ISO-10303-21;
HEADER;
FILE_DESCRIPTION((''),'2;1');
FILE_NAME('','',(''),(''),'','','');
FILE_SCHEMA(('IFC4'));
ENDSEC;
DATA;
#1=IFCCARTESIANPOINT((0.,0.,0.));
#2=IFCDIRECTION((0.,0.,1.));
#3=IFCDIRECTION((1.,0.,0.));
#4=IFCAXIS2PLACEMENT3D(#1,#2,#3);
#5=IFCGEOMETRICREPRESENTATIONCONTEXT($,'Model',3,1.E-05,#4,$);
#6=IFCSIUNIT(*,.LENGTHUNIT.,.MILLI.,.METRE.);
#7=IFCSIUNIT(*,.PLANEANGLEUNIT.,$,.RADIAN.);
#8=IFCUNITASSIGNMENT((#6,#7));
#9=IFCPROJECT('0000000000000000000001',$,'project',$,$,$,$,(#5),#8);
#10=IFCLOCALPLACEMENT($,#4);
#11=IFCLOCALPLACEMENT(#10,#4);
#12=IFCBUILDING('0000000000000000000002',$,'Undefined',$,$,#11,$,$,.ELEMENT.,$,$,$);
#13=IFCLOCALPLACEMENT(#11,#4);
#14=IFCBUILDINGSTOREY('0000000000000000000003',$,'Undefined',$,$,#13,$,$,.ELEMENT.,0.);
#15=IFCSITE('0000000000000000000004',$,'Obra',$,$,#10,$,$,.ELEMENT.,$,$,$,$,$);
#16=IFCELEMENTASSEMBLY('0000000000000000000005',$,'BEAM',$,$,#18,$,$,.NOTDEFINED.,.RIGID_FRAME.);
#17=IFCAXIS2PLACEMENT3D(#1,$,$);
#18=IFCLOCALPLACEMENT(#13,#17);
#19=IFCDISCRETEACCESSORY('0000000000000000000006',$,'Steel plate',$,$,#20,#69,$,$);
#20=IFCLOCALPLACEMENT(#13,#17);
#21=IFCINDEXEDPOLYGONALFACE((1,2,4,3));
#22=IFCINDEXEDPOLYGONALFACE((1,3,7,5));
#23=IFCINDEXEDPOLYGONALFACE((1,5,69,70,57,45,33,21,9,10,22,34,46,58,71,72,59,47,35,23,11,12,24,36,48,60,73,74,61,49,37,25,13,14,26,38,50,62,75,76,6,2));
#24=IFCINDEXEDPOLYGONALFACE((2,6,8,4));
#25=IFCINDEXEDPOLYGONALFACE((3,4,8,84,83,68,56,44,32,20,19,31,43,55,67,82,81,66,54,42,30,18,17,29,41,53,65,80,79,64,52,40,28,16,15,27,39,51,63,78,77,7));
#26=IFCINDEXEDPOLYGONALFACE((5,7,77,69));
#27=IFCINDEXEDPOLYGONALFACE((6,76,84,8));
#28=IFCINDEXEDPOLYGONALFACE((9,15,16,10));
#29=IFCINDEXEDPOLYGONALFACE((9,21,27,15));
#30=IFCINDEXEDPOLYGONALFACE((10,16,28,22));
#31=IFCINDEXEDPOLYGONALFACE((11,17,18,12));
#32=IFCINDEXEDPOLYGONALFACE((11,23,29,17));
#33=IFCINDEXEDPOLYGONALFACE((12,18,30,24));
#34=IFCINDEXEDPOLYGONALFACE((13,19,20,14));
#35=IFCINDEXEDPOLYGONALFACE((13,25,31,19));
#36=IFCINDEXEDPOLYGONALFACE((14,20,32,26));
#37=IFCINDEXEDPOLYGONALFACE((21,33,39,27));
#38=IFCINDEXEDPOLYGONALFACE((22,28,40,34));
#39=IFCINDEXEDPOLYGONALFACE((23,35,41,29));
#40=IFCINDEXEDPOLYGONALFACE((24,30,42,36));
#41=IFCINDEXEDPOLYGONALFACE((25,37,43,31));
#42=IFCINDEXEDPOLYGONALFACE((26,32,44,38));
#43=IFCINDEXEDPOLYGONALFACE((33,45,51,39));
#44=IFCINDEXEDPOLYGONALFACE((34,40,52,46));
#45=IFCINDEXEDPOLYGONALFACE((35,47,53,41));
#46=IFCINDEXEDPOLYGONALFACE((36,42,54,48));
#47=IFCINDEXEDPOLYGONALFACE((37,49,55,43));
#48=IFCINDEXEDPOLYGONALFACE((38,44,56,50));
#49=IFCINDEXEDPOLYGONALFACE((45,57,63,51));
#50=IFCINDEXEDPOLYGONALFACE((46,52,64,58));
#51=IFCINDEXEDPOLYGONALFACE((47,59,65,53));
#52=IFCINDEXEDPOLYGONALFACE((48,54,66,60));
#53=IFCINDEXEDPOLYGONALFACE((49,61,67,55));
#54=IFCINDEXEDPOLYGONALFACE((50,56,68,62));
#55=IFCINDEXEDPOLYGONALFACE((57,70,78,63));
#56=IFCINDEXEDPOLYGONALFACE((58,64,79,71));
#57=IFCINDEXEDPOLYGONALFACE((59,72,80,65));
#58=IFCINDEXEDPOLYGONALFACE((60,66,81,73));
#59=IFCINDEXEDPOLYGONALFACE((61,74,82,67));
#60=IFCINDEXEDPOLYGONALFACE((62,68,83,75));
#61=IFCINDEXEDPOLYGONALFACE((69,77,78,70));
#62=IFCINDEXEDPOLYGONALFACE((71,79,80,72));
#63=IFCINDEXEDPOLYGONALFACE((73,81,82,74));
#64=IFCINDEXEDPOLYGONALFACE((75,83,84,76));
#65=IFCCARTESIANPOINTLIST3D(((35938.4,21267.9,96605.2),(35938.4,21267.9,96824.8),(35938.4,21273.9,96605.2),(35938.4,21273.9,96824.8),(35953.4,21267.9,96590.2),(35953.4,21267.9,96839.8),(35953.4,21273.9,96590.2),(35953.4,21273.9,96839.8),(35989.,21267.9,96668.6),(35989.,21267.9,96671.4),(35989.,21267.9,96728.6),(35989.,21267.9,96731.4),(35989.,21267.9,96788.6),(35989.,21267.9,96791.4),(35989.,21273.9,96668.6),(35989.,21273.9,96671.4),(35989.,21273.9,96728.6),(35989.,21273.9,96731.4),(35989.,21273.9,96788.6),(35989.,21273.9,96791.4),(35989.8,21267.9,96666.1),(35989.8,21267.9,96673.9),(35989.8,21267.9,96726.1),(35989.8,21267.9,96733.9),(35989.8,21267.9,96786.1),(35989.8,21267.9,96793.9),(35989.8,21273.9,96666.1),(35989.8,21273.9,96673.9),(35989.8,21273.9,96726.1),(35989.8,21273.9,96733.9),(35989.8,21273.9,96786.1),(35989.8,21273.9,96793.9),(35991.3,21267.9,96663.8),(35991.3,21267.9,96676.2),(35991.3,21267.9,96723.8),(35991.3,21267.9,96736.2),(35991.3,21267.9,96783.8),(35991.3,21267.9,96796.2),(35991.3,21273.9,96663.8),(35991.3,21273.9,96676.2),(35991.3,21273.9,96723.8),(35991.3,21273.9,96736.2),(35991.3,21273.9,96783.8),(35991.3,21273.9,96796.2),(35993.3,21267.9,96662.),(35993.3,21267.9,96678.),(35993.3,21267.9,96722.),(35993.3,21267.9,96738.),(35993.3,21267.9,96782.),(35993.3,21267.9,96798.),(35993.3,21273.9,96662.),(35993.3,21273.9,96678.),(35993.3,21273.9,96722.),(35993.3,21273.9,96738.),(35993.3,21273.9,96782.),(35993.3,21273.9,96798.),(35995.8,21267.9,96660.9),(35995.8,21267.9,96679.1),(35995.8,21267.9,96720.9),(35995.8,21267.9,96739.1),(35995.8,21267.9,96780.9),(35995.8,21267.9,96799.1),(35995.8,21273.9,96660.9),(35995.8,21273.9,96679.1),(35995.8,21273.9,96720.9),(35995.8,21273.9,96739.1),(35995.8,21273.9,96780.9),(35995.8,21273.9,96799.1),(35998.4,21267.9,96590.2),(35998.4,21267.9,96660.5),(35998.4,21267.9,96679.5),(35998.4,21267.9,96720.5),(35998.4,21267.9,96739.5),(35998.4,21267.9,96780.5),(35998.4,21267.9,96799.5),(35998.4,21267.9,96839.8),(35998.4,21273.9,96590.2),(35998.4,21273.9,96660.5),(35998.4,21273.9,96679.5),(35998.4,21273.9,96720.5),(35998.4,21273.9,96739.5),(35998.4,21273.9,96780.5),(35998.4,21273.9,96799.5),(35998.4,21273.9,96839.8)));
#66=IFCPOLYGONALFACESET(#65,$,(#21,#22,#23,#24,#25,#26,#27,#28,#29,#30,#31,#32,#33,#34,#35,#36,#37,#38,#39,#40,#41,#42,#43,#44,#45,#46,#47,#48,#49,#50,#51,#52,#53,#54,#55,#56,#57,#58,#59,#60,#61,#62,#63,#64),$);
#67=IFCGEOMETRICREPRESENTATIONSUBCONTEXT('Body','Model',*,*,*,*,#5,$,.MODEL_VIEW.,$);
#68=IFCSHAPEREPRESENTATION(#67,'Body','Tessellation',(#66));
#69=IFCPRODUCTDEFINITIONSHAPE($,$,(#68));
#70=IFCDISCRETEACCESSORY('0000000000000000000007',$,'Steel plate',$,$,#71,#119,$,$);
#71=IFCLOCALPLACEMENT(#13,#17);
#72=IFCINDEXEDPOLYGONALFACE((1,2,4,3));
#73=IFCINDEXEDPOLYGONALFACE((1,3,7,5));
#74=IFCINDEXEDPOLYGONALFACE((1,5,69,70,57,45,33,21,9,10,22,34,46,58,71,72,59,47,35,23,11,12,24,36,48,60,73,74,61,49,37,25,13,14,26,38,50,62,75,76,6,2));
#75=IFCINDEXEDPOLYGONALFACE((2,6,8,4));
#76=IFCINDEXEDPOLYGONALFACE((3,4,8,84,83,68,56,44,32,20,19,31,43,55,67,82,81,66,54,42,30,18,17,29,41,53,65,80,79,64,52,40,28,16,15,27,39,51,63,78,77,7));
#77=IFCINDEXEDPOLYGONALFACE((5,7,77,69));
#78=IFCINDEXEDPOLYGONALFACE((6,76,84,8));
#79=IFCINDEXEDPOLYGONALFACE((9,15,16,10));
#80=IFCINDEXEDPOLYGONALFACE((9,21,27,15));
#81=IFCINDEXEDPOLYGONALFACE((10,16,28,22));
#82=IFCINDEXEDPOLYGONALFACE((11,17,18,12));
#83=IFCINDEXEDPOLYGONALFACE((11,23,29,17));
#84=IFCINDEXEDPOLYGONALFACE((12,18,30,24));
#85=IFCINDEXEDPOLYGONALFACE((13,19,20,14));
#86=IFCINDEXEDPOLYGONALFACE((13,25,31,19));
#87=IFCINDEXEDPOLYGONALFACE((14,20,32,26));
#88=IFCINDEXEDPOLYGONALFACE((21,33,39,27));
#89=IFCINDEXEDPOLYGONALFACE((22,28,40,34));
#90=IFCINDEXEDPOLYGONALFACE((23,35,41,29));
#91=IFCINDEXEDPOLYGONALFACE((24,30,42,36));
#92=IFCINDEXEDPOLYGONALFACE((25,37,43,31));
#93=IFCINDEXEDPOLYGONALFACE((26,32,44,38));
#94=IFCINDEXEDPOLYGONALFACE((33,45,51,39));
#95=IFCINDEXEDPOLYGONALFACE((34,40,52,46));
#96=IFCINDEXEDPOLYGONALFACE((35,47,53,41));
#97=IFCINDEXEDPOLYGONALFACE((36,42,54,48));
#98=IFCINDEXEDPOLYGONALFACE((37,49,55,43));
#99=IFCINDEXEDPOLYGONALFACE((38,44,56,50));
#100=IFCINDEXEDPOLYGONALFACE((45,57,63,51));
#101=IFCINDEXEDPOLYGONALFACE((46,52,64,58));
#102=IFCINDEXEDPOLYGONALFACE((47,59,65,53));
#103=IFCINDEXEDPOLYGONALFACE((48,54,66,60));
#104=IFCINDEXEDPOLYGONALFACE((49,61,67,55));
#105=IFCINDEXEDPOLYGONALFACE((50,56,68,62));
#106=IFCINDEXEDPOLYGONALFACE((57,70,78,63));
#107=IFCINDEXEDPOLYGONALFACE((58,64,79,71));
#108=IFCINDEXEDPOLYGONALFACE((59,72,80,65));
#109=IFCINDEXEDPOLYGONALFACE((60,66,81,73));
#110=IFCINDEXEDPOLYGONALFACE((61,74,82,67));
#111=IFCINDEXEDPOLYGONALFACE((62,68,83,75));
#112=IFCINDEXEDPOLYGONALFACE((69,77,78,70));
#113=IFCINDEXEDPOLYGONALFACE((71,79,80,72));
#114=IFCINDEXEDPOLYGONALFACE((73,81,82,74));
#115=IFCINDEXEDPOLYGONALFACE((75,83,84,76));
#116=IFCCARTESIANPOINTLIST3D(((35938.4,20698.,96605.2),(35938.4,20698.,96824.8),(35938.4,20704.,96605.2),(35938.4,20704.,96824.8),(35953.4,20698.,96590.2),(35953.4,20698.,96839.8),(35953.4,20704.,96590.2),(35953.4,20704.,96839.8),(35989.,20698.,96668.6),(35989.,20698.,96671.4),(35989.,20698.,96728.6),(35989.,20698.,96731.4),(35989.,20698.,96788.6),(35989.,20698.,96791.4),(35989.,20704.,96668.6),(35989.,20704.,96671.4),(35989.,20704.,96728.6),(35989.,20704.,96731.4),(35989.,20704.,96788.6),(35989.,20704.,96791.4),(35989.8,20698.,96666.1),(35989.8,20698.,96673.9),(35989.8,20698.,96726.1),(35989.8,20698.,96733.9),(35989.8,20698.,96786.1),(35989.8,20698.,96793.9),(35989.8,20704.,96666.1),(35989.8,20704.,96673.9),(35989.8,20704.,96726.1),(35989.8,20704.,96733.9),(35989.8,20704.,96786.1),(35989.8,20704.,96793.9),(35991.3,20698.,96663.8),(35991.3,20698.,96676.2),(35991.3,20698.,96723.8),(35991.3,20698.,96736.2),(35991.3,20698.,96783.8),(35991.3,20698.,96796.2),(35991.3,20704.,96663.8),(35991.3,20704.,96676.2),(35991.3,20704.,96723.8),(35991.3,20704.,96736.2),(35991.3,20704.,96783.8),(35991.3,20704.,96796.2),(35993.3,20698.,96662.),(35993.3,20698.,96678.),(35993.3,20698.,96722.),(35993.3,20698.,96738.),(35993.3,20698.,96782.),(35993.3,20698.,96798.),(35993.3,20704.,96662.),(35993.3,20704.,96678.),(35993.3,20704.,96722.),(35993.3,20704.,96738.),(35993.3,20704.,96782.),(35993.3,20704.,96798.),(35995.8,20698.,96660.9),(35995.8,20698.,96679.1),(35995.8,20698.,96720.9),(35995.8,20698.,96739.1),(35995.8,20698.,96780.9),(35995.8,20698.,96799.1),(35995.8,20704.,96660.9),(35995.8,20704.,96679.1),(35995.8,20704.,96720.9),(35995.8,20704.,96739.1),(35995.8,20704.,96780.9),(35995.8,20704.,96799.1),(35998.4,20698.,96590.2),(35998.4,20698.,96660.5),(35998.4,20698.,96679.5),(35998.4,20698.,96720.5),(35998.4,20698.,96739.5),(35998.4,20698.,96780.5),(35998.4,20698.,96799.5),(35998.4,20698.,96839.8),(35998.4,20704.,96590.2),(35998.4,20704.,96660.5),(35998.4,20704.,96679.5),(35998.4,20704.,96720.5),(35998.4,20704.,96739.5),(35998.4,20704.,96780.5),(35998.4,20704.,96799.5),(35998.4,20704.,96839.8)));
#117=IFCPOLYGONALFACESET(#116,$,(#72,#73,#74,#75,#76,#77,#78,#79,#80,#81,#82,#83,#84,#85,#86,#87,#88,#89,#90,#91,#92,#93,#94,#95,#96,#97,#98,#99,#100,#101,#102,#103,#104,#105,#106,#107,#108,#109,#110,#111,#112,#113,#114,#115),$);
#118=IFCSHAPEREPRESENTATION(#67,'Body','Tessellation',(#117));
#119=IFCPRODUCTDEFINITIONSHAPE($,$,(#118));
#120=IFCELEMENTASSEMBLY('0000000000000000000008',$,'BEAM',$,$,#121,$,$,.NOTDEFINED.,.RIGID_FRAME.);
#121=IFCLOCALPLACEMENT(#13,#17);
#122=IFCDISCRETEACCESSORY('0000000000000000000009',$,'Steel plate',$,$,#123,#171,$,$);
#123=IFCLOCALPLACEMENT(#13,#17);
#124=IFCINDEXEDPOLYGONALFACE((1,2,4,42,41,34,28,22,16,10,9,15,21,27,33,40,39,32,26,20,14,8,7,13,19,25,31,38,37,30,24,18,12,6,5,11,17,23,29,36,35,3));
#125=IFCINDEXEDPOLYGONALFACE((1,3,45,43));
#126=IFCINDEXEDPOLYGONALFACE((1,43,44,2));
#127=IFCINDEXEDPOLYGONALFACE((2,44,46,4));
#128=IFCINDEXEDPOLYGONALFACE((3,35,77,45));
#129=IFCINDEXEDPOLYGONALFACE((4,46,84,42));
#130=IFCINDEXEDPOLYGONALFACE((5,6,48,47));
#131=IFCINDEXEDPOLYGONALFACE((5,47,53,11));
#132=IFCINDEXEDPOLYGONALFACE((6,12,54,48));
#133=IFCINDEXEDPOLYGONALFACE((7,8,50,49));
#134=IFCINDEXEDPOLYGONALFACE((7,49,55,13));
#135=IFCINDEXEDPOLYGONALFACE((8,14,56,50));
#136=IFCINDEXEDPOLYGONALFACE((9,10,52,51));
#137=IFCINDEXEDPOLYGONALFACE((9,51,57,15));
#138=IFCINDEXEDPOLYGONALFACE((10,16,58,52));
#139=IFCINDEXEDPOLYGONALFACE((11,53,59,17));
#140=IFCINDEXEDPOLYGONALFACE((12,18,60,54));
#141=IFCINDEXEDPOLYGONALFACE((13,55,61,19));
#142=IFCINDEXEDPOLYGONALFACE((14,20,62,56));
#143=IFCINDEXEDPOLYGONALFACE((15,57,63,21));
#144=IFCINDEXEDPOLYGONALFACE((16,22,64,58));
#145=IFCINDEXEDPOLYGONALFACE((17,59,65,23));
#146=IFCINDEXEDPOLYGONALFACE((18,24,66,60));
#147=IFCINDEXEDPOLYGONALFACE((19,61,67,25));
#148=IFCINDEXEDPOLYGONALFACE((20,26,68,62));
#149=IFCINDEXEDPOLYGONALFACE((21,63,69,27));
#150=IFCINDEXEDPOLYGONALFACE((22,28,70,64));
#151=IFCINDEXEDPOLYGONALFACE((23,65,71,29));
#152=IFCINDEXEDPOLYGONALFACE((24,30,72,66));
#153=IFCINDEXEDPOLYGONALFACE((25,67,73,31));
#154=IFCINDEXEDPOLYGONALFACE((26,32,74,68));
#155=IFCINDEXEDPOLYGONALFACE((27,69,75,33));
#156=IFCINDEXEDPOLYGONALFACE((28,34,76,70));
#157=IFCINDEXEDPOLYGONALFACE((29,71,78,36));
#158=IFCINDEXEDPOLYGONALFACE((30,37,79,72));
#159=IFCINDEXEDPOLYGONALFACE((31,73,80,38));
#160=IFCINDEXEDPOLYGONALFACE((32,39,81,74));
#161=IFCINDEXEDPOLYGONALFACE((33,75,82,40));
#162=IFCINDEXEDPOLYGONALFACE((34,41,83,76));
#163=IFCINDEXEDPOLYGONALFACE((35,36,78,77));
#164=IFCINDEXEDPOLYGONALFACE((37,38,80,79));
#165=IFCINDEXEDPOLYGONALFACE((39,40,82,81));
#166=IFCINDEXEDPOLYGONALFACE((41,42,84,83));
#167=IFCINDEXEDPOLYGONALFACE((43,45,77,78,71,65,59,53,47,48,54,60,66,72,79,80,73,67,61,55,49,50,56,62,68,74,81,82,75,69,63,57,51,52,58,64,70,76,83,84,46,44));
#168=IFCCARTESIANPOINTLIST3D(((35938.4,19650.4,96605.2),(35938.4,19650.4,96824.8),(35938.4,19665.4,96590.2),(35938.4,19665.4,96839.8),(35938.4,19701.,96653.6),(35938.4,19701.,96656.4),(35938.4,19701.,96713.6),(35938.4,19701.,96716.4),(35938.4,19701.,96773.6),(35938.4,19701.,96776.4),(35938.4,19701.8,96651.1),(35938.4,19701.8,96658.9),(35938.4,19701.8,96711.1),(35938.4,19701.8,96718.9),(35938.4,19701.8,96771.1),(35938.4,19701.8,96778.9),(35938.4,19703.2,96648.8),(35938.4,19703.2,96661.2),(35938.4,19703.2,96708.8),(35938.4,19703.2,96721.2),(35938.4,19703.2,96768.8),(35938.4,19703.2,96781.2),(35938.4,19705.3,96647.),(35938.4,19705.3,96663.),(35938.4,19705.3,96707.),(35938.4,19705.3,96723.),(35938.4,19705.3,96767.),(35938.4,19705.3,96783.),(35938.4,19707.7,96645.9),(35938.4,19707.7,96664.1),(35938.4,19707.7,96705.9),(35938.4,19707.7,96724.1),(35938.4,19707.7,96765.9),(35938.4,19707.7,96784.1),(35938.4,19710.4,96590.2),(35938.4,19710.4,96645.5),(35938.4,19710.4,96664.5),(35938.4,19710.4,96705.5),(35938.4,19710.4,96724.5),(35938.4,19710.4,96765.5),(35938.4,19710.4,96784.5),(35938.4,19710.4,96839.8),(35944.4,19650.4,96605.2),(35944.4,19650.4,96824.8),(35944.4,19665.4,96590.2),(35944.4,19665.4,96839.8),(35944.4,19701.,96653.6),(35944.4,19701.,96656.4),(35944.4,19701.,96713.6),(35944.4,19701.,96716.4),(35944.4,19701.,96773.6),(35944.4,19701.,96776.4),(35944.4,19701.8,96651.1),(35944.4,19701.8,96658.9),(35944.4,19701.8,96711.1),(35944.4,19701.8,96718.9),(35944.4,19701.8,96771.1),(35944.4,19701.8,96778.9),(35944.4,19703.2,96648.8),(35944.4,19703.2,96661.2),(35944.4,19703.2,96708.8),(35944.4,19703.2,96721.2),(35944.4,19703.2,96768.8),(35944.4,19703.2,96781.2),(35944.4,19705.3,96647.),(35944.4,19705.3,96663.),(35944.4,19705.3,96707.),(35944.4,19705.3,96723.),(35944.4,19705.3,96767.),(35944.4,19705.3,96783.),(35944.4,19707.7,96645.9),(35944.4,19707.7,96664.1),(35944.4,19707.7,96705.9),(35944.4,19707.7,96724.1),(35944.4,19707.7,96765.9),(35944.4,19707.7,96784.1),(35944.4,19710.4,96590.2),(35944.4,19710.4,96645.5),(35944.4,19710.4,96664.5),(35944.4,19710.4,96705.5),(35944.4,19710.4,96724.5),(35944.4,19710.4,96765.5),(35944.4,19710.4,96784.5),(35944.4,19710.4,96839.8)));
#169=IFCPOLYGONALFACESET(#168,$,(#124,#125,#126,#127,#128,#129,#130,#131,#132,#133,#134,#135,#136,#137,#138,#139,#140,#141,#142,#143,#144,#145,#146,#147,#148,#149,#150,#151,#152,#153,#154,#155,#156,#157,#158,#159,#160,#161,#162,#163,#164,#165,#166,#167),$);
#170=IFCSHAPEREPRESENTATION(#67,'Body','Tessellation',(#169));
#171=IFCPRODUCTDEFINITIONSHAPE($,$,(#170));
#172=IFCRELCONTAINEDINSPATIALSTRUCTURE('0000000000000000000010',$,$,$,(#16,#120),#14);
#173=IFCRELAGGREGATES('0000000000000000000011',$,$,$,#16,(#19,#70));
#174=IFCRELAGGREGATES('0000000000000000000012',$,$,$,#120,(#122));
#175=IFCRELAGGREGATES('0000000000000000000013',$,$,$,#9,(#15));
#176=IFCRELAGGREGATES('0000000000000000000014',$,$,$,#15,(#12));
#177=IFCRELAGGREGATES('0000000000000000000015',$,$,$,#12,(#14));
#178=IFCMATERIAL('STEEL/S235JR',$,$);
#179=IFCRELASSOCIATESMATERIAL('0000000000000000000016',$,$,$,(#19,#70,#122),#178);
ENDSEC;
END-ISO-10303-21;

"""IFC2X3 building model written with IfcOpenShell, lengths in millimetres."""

from ifc_helpers import new_model, si_unit, frame, origin_with_axes, origin_2d_with_axis, place, context, subcontext, project, spatial, polyline, circle, outline, extrude, source, transform, mapped, material, element, aggregate, save


model = new_model("IFC2X3")

# Units and contexts
model_context = context("Model", 3, precision=1e-05, world=origin_with_axes())
body_context = subcontext(model_context, "Body", "Model", "MODEL_VIEW")
ifc_project = project(units=[si_unit("LENGTHUNIT", "METRE", prefix="MILLI"), si_unit("PLANEANGLEUNIT", "RADIAN")], contexts=[model_context])

# Site, building, storey
site_placement = place(None, origin_with_axes())
site = spatial("IfcSite", under=ifc_project, at=site_placement, Name="Obra", CompositionType="ELEMENT")
building_placement = place(site_placement, origin_with_axes())
building = spatial("IfcBuilding", under=site, at=building_placement, Name="Undefined", CompositionType="ELEMENT")
storey_placement = place(building_placement, origin_with_axes())
storey = spatial("IfcBuildingStorey", under=building, at=storey_placement, Name="Undefined", CompositionType="ELEMENT", Elevation=0.0)

# Shared definitions
ifc_material = material(Name="STEEL/S235JR")

# Element assembly, discrete accessories, openings
assembly_1_placement = place(storey_placement, origin_with_axes())
assembly_1 = element("IfcElementAssembly", 1, at=assembly_1_placement, inside=storey, Name="BEAM", AssemblyPlace="NOTDEFINED", PredefinedType="RIGID_FRAME")
discrete_accessory_1_placement = place(assembly_1_placement, frame((35998.4, 21270.9, 96590.2), z_axis=(0.0, 1.0, 0.0), x_axis=(-1.0, 0.0, 0.0)))
discrete_accessory_1 = element("IfcDiscreteAccessory", 2, at=discrete_accessory_1_placement, material=ifc_material, Name="Steel plate", context=body_context, shape_type="SweptSolid", body=[
    extrude(outline(polyline([(0.0, 0.0), (45.0, 0.0), (60.0, 15.0), (60.0, 234.6), (45.0, 249.6), (0.0, 249.6), (0.0, 0.0)])), frame((0.0, 0.0, -3.0), z_axis=(0.0, 0.0, 1.0), x_axis=(1.0, 0.0, 0.0)), (0.0, 0.0, 1.0), 6.0),
])
shared_shape_1 = source(origin_with_axes(), body_context, "Body", "SweptSolid", [
    extrude(circle(Radius=9.5, at=origin_2d_with_axis()), frame((0.0, -9.2, 0.0), z_axis=(0.0, 1.0, 0.0), x_axis=(1.0, 0.0, 0.0)), (0.0, 0.0, 1.0), 6.2),
])
opening_1_placement = place(assembly_1_placement, frame((35948.4, 21277.0, 96850.0), z_axis=(1.0, 0.0, 0.0), x_axis=(0.0, 0.0, -1.0)))
element("IfcOpeningElement", 3, at=opening_1_placement, cuts=discrete_accessory_1, ObjectType="Opening", context=body_context, shape_type="MappedRepresentation", body=[
    mapped(shared_shape_1, transform((60.0, 0.0, 50.0))),
    mapped(shared_shape_1, transform((120.0, 0.0, 50.0))),
    mapped(shared_shape_1, transform((180.0, 0.0, 50.0))),
])
discrete_accessory_2_placement = place(assembly_1_placement, frame((35998.4, 20701.0, 96590.2), z_axis=(0.0, 1.0, 0.0), x_axis=(-1.0, 0.0, 0.0)))
discrete_accessory_2 = element("IfcDiscreteAccessory", 4, at=discrete_accessory_2_placement, material=ifc_material, Name="Steel plate", context=body_context, shape_type="SweptSolid", body=[
    extrude(outline(polyline([(0.0, 0.0), (45.0, 0.0), (60.0, 15.0), (60.0, 234.6), (45.0, 249.6), (0.0, 249.6), (0.0, 0.0)])), frame((0.0, 0.0, -3.0), z_axis=(0.0, 0.0, 1.0), x_axis=(1.0, 0.0, 0.0)), (0.0, 0.0, 1.0), 6.0),
])
opening_2_placement = place(assembly_1_placement, frame((35948.4, 20707.1, 96850.0), z_axis=(1.0, 0.0, 0.0), x_axis=(0.0, 0.0, -1.0)))
element("IfcOpeningElement", 5, at=opening_2_placement, cuts=discrete_accessory_2, ObjectType="Opening", context=body_context, shape_type="MappedRepresentation", body=[
    mapped(shared_shape_1, transform((60.0, 0.0, 50.0))),
    mapped(shared_shape_1, transform((120.0, 0.0, 50.0))),
    mapped(shared_shape_1, transform((180.0, 0.0, 50.0))),
])
aggregate(assembly_1, [discrete_accessory_1, discrete_accessory_2])

# Element assembly, discrete accessory, opening
assembly_2_placement = place(storey_placement, origin_with_axes())
assembly_2 = element("IfcElementAssembly", 6, at=assembly_2_placement, inside=storey, Name="BEAM", AssemblyPlace="NOTDEFINED", PredefinedType="RIGID_FRAME")
discrete_accessory_3_placement = place(assembly_2_placement, frame((35941.4, 19710.4, 96590.2), z_axis=(-1.0, 0.0, 0.0), x_axis=(0.0, -1.0, 0.0)))
discrete_accessory_3 = element("IfcDiscreteAccessory", 7, at=discrete_accessory_3_placement, material=ifc_material, Name="Steel plate", context=body_context, shape_type="SweptSolid", body=[
    extrude(outline(polyline([(0.0, 0.0), (45.0, 0.0), (60.0, 15.0), (60.0, 234.6), (45.0, 249.6), (0.0, 249.6), (0.0, 0.0)])), frame((0.0, 0.0, -3.0), z_axis=(0.0, 0.0, 1.0), x_axis=(1.0, 0.0, 0.0)), (0.0, 0.0, 1.0), 6.0),
])
shared_shape_2 = source(origin_with_axes(), body_context, "Body", "SweptSolid", [
    extrude(circle(Radius=9.5, at=origin_2d_with_axis()), frame((0.0, -9.4, 0.0), z_axis=(0.0, 1.0, 0.0), x_axis=(1.0, 0.0, 0.0)), (0.0, 0.0, 1.0), 6.2),
])
opening_3_placement = place(assembly_2_placement, frame((35935.1, 19660.4, 96850.0), z_axis=(0.0, 1.0, 0.0), x_axis=(0.0, 0.0, -1.0)))
element("IfcOpeningElement", 8, at=opening_3_placement, cuts=discrete_accessory_3, ObjectType="Opening", context=body_context, shape_type="MappedRepresentation", body=[
    mapped(shared_shape_2, transform((75.0, 0.0, 50.0))),
    mapped(shared_shape_2, transform((135.0, 0.0, 50.0))),
    mapped(shared_shape_2, transform((195.0, 0.0, 50.0))),
])

aggregate(assembly_2, [discrete_accessory_3])

save(model, "model.ifc")
